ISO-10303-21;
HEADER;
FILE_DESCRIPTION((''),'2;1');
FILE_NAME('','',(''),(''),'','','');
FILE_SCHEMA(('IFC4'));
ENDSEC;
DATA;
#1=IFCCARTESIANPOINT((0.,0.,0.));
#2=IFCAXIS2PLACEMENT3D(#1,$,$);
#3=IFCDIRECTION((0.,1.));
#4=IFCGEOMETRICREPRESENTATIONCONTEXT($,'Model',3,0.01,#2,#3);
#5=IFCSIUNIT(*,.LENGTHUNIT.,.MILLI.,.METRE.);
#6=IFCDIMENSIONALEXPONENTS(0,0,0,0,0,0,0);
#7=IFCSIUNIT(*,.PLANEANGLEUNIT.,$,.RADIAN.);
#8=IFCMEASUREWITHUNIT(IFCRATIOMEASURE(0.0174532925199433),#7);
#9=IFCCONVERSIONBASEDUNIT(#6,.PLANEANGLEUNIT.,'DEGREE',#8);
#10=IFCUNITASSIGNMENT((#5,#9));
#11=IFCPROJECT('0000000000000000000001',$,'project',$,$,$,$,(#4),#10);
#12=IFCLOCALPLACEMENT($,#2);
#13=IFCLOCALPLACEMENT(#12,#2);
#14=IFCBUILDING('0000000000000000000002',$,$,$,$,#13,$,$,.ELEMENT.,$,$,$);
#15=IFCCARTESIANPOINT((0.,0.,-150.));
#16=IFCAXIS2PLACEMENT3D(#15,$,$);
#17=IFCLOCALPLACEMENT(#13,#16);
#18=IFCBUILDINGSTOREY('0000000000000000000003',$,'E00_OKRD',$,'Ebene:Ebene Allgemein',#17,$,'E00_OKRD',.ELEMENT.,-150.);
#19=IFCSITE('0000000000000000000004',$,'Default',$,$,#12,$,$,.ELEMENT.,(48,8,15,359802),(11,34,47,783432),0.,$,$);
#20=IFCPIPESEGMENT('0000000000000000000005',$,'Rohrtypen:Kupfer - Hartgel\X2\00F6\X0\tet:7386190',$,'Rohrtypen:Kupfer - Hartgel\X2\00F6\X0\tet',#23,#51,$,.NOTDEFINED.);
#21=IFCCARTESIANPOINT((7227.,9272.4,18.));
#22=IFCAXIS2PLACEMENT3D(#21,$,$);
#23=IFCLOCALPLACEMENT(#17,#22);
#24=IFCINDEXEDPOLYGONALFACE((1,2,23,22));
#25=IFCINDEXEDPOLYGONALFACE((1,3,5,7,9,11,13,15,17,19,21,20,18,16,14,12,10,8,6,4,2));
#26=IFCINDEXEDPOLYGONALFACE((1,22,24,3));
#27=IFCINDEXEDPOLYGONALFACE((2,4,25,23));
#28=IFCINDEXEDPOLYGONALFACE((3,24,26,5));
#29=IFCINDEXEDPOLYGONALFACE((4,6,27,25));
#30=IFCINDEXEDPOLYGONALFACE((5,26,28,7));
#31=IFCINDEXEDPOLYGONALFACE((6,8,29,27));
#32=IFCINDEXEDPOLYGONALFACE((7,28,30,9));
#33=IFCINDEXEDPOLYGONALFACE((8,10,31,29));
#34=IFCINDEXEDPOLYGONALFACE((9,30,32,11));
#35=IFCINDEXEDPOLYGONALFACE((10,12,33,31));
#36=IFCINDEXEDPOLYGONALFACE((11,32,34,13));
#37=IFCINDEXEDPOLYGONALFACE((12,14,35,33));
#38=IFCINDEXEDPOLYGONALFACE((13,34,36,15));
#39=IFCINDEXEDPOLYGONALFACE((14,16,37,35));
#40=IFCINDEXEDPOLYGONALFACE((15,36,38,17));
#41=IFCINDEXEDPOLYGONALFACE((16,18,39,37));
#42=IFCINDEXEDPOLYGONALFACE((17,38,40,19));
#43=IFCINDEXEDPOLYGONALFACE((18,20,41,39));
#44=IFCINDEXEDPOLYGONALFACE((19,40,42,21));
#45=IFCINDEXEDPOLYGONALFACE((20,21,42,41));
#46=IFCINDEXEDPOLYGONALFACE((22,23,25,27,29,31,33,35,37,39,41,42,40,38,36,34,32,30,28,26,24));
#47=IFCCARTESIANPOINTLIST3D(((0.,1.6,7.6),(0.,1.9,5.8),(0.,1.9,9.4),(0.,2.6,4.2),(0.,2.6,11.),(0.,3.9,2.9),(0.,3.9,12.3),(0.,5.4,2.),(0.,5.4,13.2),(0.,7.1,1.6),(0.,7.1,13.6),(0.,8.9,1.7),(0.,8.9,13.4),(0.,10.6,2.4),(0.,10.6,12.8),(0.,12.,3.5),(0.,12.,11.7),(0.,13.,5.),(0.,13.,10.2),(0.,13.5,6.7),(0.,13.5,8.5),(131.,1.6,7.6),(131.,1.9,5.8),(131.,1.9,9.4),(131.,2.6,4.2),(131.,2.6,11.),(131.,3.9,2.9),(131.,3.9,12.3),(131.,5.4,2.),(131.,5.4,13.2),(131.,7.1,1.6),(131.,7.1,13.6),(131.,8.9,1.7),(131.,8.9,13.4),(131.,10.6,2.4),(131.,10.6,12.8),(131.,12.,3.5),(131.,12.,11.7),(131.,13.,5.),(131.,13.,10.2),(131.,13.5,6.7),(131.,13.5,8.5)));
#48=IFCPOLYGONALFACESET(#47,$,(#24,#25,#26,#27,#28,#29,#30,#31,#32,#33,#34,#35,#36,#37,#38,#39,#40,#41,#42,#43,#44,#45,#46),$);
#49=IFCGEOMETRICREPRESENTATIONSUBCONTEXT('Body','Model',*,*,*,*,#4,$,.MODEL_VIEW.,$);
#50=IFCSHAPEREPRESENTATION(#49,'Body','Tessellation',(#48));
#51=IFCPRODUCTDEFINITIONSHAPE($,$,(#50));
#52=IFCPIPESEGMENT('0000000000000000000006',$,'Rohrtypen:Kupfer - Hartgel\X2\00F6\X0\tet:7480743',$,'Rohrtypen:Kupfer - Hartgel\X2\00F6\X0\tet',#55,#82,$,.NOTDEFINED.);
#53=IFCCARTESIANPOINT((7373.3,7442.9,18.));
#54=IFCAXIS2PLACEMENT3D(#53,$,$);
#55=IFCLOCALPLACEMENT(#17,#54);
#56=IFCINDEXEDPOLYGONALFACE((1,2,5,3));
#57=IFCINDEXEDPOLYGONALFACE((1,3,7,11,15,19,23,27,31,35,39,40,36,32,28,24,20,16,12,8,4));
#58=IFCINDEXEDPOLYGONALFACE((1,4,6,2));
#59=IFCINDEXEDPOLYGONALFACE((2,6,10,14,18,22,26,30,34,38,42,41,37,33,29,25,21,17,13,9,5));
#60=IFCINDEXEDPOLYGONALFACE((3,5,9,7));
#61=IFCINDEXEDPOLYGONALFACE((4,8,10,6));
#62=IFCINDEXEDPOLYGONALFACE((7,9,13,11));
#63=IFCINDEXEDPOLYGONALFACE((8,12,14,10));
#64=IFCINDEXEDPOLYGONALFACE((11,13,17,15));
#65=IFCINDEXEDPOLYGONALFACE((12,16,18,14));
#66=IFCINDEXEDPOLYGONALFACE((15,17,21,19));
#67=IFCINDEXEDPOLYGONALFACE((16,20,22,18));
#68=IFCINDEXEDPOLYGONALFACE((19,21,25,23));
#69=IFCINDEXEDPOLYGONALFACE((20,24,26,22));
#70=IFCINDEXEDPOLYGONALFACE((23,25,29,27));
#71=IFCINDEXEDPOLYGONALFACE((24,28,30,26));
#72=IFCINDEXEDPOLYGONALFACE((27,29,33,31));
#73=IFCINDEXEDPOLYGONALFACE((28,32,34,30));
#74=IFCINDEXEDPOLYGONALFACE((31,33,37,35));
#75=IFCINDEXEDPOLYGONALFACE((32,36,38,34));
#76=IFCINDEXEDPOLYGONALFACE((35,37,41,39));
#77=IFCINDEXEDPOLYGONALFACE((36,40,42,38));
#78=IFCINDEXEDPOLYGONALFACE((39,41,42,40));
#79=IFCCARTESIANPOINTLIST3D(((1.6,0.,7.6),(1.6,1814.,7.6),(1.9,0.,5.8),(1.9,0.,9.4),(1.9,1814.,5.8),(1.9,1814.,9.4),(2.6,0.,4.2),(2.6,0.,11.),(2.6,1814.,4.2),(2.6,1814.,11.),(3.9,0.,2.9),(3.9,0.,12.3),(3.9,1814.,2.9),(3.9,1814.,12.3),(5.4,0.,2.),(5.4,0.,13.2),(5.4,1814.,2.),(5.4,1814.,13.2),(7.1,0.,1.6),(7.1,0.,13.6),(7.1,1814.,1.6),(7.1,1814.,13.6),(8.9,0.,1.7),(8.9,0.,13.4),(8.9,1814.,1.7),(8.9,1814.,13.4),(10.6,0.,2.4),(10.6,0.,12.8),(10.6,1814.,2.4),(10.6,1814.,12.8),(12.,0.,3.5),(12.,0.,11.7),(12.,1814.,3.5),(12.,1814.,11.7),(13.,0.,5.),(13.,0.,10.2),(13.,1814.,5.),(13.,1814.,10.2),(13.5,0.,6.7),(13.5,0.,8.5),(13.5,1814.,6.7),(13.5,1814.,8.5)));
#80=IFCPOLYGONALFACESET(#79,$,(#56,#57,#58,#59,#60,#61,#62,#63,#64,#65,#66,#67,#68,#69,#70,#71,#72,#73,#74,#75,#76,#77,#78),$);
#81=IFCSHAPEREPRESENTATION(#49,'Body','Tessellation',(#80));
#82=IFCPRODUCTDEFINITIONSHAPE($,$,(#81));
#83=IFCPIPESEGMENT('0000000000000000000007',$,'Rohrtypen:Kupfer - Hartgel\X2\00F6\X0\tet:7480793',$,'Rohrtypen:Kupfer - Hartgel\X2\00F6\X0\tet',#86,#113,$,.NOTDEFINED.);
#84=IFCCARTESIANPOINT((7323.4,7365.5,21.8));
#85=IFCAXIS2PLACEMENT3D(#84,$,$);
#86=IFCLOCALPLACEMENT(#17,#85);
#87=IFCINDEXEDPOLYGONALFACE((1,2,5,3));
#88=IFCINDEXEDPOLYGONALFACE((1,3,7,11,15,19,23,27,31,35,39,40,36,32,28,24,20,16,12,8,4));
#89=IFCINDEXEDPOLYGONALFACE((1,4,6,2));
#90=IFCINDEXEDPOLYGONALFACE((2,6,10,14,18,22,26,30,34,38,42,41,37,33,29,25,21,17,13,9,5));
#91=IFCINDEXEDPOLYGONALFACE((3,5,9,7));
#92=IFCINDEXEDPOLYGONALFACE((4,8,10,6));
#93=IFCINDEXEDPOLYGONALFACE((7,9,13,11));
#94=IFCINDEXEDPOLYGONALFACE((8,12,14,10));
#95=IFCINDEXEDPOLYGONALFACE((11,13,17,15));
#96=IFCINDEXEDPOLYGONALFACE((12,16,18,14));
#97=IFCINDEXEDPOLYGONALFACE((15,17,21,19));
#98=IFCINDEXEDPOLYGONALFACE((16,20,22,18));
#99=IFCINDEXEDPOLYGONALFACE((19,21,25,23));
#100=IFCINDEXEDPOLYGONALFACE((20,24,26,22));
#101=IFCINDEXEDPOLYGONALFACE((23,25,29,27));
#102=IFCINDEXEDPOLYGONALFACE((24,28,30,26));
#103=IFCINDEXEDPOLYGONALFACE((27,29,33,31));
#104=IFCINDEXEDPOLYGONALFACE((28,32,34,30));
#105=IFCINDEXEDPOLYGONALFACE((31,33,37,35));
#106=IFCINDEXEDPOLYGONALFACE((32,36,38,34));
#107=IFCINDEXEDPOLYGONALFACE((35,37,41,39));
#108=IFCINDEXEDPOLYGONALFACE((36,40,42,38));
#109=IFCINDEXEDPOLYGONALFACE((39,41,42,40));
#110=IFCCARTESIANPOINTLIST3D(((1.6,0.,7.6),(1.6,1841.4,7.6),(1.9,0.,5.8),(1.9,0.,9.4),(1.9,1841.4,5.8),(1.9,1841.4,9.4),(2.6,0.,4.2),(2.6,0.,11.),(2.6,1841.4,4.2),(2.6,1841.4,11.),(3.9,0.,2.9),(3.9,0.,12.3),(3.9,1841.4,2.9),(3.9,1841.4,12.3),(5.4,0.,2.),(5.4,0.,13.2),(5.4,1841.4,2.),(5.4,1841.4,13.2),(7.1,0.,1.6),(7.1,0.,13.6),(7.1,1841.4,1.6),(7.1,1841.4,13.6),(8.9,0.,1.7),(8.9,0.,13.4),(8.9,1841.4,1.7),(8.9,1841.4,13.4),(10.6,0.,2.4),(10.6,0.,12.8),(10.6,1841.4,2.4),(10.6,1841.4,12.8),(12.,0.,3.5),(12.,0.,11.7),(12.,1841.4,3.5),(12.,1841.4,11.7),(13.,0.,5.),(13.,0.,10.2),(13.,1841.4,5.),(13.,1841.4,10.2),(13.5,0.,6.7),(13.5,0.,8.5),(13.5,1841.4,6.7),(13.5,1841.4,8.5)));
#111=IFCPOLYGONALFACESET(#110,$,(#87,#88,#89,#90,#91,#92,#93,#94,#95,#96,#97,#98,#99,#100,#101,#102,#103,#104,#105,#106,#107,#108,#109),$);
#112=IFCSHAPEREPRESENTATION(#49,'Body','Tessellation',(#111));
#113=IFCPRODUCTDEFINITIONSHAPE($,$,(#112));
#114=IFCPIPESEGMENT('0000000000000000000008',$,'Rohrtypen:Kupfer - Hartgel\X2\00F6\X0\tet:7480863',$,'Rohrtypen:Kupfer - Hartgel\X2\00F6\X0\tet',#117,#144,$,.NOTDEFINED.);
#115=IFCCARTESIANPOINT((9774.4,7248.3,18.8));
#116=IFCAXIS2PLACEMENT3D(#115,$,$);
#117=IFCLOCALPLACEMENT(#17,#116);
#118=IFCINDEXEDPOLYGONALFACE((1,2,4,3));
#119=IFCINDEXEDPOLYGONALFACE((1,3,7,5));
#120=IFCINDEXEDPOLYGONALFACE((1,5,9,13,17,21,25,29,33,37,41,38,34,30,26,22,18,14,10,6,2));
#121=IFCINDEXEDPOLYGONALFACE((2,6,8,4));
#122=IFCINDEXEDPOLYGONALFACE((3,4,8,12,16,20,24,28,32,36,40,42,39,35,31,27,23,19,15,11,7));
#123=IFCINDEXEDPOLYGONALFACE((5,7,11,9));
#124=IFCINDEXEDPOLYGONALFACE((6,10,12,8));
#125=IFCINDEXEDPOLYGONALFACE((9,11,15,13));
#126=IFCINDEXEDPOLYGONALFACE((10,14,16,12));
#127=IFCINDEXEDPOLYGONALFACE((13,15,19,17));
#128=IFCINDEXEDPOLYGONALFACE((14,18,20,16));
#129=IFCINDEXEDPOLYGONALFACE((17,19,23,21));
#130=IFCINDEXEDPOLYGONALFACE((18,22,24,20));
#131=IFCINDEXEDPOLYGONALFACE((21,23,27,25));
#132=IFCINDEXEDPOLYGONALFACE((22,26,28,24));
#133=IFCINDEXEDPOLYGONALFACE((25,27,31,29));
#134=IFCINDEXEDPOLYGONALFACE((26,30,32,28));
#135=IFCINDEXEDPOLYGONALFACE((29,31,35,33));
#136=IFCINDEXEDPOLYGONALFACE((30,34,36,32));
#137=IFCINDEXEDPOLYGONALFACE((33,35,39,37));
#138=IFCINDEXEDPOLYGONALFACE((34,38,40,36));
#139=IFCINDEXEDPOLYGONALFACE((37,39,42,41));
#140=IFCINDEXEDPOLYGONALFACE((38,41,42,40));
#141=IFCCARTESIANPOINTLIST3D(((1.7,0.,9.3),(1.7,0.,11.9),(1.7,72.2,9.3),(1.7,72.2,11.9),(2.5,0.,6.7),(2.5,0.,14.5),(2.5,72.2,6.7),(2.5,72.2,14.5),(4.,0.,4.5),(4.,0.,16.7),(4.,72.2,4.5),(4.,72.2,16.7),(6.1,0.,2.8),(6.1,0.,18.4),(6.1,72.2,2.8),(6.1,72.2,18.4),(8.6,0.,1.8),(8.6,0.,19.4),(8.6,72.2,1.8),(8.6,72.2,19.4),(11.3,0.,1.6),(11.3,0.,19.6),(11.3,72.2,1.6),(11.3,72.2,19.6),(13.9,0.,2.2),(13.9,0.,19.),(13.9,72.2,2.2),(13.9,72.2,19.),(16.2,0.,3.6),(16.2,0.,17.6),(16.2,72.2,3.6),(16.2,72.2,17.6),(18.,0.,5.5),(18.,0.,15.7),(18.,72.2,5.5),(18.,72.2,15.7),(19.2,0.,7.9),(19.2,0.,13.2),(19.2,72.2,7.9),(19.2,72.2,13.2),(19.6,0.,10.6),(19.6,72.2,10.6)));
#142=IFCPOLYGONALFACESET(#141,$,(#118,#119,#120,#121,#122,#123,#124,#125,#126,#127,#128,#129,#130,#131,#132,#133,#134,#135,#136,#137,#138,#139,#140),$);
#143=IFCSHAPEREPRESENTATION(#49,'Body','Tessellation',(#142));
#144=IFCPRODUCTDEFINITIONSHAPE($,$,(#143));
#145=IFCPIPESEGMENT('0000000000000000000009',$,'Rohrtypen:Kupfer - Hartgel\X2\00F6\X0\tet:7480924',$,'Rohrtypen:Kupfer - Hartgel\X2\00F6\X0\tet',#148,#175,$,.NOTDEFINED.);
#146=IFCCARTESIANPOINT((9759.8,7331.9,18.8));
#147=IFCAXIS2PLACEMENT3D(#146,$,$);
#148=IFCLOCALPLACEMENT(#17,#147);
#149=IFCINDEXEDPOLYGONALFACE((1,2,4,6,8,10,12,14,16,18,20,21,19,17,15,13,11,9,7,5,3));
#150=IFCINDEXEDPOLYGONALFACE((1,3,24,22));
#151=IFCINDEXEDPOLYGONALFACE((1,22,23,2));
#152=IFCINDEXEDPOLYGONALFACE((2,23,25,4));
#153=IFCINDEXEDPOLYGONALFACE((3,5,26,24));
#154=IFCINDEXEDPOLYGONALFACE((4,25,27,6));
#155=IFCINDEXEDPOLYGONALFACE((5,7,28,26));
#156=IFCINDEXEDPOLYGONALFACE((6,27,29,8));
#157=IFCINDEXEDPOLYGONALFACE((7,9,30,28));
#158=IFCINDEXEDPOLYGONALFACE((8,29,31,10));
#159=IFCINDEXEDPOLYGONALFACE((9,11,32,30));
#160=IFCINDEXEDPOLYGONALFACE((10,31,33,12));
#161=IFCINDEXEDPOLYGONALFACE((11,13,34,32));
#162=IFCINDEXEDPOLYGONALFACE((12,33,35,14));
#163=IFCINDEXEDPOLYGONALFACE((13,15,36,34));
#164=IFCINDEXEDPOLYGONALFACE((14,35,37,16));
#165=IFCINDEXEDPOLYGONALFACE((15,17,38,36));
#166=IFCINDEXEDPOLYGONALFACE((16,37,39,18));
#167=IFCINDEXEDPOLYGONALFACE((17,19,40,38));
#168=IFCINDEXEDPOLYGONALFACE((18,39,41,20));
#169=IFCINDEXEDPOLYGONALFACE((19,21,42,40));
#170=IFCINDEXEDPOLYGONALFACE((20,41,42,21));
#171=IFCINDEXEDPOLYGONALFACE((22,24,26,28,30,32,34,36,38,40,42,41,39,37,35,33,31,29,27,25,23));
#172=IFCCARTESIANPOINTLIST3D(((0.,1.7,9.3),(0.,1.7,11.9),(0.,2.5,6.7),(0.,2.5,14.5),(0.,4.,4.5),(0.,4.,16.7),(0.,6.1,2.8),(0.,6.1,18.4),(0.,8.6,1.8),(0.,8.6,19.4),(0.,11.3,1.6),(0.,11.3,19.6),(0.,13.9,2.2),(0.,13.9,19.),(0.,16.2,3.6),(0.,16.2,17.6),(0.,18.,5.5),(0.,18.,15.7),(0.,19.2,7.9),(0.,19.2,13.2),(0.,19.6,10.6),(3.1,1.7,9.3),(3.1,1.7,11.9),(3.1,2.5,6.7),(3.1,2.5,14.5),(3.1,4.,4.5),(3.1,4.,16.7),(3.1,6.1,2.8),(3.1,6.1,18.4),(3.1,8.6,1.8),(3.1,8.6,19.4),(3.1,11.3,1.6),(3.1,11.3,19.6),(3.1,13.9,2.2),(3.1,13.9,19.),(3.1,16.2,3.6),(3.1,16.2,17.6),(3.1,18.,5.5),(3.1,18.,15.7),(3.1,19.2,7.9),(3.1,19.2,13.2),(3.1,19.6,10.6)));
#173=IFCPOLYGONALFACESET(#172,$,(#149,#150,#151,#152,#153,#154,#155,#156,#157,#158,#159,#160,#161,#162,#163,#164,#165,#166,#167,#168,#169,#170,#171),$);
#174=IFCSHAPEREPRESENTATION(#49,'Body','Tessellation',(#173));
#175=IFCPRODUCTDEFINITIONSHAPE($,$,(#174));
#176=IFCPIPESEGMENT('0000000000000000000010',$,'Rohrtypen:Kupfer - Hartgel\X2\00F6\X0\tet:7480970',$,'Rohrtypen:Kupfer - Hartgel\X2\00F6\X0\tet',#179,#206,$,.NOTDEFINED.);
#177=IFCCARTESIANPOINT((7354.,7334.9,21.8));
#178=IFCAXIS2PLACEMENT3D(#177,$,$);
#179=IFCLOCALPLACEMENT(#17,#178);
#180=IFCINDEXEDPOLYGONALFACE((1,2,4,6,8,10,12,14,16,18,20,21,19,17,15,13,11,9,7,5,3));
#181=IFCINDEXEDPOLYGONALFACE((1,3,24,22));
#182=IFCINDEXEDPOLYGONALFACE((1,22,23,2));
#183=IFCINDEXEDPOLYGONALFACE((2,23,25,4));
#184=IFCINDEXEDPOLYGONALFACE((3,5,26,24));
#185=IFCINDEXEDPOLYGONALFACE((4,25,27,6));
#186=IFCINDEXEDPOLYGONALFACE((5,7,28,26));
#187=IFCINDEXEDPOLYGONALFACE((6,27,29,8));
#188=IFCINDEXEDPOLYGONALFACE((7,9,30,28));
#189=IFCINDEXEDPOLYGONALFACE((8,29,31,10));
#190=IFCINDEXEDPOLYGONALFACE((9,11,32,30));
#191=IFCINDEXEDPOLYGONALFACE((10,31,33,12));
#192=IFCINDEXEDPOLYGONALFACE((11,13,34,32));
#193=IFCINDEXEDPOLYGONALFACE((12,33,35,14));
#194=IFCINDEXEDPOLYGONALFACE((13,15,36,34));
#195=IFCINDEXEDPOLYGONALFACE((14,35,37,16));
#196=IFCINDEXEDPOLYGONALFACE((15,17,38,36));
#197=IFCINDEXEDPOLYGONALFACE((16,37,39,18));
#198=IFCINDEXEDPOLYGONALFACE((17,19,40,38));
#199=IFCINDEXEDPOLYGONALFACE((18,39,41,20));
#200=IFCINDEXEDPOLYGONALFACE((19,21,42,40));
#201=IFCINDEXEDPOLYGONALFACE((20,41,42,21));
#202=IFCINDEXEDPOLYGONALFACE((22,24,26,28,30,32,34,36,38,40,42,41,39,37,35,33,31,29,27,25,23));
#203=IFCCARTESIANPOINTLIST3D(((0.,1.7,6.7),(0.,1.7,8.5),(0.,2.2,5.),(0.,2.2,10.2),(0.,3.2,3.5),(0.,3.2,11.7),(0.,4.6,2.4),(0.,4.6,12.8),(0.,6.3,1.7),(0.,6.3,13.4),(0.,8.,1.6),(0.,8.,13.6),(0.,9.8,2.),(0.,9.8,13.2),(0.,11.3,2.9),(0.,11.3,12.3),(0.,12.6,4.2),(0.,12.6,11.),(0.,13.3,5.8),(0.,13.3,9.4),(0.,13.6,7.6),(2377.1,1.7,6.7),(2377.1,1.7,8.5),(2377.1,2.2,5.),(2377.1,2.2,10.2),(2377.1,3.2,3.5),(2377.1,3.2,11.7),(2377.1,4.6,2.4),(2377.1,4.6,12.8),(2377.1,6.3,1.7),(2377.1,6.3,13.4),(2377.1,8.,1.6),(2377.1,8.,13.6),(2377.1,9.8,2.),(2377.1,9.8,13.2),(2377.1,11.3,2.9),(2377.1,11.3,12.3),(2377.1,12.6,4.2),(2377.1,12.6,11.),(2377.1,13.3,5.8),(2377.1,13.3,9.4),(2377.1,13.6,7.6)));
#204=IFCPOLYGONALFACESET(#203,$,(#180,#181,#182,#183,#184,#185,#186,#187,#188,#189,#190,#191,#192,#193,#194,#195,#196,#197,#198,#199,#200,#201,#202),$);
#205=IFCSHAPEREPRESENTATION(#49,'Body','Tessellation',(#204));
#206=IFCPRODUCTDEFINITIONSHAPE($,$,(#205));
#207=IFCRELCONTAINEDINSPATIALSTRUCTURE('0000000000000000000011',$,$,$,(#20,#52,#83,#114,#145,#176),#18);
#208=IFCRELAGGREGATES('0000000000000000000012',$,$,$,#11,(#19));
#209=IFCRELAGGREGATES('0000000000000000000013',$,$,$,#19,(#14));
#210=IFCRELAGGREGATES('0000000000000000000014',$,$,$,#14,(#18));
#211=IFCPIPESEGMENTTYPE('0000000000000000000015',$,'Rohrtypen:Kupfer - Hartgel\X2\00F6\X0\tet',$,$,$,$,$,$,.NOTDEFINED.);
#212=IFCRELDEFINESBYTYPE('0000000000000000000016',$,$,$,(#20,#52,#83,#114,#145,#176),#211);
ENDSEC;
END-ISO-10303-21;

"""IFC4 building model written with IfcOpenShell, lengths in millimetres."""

from ifc_helpers import new_model, entity, si_unit, converted_unit, direction, frame, frame_2d, origin, origin_2d_with_axis, place, context, subcontext, project, spatial, circle, extrude, type_object, element, save


model = new_model("IFC4")

# Units and contexts
model_context = context("Model", 3, precision=0.01, world=origin(), true_north=direction((0.0, 1.0)))
body_context = subcontext(model_context, "Body", "Model", "MODEL_VIEW")
ifc_project = project(units=[si_unit("LENGTHUNIT", "METRE", prefix="MILLI"), converted_unit("PLANEANGLEUNIT", "DEGREE", entity("IfcRatioMeasure", 0.0174532925199433), si_unit("PLANEANGLEUNIT", "RADIAN"), dimensions=[0, 0, 0, 0, 0, 0, 0])], contexts=[model_context])

# Site, building, storey
site_placement = place(None, origin())
site = spatial("IfcSite", under=ifc_project, at=site_placement, Name="Default", CompositionType="ELEMENT", RefLatitude=(48, 8, 15, 359802), RefLongitude=(11, 34, 47, 783432), RefElevation=0.0)
building_placement = place(site_placement, origin())
building = spatial("IfcBuilding", under=site, at=building_placement, CompositionType="ELEMENT")
storey_placement = place(building_placement, frame((0.0, 0.0, -150.0)))
storey = spatial("IfcBuildingStorey", under=building, at=storey_placement, Name="E00_OKRD", ObjectType="Ebene:Ebene Allgemein", LongName="E00_OKRD", CompositionType="ELEMENT", Elevation=-150.0)

# Pipe segments
pipe_segment_type = type_object("IfcPipeSegmentType", Name="Rohrtypen:Kupfer - Hartgelötet", PredefinedType="NOTDEFINED")
pipe_segment_1_placement = place(storey_placement, frame((7227.0, 9272.4, 18.0)))
element("IfcPipeSegment", 1, at=pipe_segment_1_placement, inside=storey, type_object=pipe_segment_type, Name="Rohrtypen:Kupfer - Hartgelötet:7386190", ObjectType="Rohrtypen:Kupfer - Hartgelötet", PredefinedType="NOTDEFINED", context=body_context, shape_type="SweptSolid", body=[
    extrude(circle(Radius=6.0, at=frame_2d((0.0, 0.0), x_axis=(1.0, 0.0))), frame((0.0, 7.6, 7.6), z_axis=(1.0, 0.0, 0.0), x_axis=(0.0, -1.0, 0.0)), (0.0, 0.0, 1.0), 131.0),
])
pipe_segment_2_placement = place(storey_placement, frame((7373.3, 7442.9, 18.0)))
element("IfcPipeSegment", 2, at=pipe_segment_2_placement, inside=storey, type_object=pipe_segment_type, Name="Rohrtypen:Kupfer - Hartgelötet:7480743", ObjectType="Rohrtypen:Kupfer - Hartgelötet", PredefinedType="NOTDEFINED", context=body_context, shape_type="SweptSolid", body=[
    extrude(circle(Radius=6.0, at=origin_2d_with_axis()), frame((7.6, 0.0, 7.6), z_axis=(0.0, 1.0, 0.0), x_axis=(-1.0, 0.0, 0.0)), (0.0, 0.0, 1.0), 1814.0),
])
pipe_segment_3_placement = place(storey_placement, frame((7323.4, 7365.5, 21.8)))
element("IfcPipeSegment", 3, at=pipe_segment_3_placement, inside=storey, type_object=pipe_segment_type, Name="Rohrtypen:Kupfer - Hartgelötet:7480793", ObjectType="Rohrtypen:Kupfer - Hartgelötet", PredefinedType="NOTDEFINED", context=body_context, shape_type="SweptSolid", body=[
    extrude(circle(Radius=6.0, at=frame_2d((0.0, 0.0), x_axis=(1.0, 0.0))), frame((7.6, 0.0, 7.6), z_axis=(0.0, 1.0, 0.0), x_axis=(-1.0, 0.0, 0.0)), (0.0, 0.0, 1.0), 1841.4),
])
pipe_segment_4_placement = place(storey_placement, frame((9774.4, 7248.3, 18.8)))
element("IfcPipeSegment", 4, at=pipe_segment_4_placement, inside=storey, type_object=pipe_segment_type, Name="Rohrtypen:Kupfer - Hartgelötet:7480863", ObjectType="Rohrtypen:Kupfer - Hartgelötet", PredefinedType="NOTDEFINED", context=body_context, shape_type="SweptSolid", body=[
    extrude(circle(Radius=9.0, at=frame_2d((0.0, 0.0), x_axis=(1.0, 0.0))), frame((10.6, 0.0, 10.6), z_axis=(0.0, 1.0, 0.0), x_axis=(1.0, 0.0, 0.0)), (0.0, 0.0, 1.0), 72.2),
])
pipe_segment_5_placement = place(storey_placement, frame((9759.8, 7331.9, 18.8)))
element("IfcPipeSegment", 5, at=pipe_segment_5_placement, inside=storey, type_object=pipe_segment_type, Name="Rohrtypen:Kupfer - Hartgelötet:7480924", ObjectType="Rohrtypen:Kupfer - Hartgelötet", PredefinedType="NOTDEFINED", context=body_context, shape_type="SweptSolid", body=[
    extrude(circle(Radius=9.0, at=frame_2d((0.0, 0.0), x_axis=(1.0, 0.0))), frame((0.0, 10.6, 10.6), z_axis=(1.0, 0.0, 0.0), x_axis=(0.0, 1.0, 0.0)), (0.0, 0.0, 1.0), 3.1),
])
pipe_segment_6_placement = place(storey_placement, frame((7354.0, 7334.9, 21.8)))
element("IfcPipeSegment", 6, at=pipe_segment_6_placement, inside=storey, type_object=pipe_segment_type, Name="Rohrtypen:Kupfer - Hartgelötet:7480970", ObjectType="Rohrtypen:Kupfer - Hartgelötet", PredefinedType="NOTDEFINED", context=body_context, shape_type="SweptSolid", body=[
    extrude(circle(Radius=6.0, at=frame_2d((0.0, 0.0), x_axis=(1.0, 0.0))), frame((0.0, 7.6, 7.6), z_axis=(1.0, 0.0, 0.0), x_axis=(0.0, 1.0, 0.0)), (0.0, 0.0, 1.0), 2377.1),
])

save(model, "model.ifc")
